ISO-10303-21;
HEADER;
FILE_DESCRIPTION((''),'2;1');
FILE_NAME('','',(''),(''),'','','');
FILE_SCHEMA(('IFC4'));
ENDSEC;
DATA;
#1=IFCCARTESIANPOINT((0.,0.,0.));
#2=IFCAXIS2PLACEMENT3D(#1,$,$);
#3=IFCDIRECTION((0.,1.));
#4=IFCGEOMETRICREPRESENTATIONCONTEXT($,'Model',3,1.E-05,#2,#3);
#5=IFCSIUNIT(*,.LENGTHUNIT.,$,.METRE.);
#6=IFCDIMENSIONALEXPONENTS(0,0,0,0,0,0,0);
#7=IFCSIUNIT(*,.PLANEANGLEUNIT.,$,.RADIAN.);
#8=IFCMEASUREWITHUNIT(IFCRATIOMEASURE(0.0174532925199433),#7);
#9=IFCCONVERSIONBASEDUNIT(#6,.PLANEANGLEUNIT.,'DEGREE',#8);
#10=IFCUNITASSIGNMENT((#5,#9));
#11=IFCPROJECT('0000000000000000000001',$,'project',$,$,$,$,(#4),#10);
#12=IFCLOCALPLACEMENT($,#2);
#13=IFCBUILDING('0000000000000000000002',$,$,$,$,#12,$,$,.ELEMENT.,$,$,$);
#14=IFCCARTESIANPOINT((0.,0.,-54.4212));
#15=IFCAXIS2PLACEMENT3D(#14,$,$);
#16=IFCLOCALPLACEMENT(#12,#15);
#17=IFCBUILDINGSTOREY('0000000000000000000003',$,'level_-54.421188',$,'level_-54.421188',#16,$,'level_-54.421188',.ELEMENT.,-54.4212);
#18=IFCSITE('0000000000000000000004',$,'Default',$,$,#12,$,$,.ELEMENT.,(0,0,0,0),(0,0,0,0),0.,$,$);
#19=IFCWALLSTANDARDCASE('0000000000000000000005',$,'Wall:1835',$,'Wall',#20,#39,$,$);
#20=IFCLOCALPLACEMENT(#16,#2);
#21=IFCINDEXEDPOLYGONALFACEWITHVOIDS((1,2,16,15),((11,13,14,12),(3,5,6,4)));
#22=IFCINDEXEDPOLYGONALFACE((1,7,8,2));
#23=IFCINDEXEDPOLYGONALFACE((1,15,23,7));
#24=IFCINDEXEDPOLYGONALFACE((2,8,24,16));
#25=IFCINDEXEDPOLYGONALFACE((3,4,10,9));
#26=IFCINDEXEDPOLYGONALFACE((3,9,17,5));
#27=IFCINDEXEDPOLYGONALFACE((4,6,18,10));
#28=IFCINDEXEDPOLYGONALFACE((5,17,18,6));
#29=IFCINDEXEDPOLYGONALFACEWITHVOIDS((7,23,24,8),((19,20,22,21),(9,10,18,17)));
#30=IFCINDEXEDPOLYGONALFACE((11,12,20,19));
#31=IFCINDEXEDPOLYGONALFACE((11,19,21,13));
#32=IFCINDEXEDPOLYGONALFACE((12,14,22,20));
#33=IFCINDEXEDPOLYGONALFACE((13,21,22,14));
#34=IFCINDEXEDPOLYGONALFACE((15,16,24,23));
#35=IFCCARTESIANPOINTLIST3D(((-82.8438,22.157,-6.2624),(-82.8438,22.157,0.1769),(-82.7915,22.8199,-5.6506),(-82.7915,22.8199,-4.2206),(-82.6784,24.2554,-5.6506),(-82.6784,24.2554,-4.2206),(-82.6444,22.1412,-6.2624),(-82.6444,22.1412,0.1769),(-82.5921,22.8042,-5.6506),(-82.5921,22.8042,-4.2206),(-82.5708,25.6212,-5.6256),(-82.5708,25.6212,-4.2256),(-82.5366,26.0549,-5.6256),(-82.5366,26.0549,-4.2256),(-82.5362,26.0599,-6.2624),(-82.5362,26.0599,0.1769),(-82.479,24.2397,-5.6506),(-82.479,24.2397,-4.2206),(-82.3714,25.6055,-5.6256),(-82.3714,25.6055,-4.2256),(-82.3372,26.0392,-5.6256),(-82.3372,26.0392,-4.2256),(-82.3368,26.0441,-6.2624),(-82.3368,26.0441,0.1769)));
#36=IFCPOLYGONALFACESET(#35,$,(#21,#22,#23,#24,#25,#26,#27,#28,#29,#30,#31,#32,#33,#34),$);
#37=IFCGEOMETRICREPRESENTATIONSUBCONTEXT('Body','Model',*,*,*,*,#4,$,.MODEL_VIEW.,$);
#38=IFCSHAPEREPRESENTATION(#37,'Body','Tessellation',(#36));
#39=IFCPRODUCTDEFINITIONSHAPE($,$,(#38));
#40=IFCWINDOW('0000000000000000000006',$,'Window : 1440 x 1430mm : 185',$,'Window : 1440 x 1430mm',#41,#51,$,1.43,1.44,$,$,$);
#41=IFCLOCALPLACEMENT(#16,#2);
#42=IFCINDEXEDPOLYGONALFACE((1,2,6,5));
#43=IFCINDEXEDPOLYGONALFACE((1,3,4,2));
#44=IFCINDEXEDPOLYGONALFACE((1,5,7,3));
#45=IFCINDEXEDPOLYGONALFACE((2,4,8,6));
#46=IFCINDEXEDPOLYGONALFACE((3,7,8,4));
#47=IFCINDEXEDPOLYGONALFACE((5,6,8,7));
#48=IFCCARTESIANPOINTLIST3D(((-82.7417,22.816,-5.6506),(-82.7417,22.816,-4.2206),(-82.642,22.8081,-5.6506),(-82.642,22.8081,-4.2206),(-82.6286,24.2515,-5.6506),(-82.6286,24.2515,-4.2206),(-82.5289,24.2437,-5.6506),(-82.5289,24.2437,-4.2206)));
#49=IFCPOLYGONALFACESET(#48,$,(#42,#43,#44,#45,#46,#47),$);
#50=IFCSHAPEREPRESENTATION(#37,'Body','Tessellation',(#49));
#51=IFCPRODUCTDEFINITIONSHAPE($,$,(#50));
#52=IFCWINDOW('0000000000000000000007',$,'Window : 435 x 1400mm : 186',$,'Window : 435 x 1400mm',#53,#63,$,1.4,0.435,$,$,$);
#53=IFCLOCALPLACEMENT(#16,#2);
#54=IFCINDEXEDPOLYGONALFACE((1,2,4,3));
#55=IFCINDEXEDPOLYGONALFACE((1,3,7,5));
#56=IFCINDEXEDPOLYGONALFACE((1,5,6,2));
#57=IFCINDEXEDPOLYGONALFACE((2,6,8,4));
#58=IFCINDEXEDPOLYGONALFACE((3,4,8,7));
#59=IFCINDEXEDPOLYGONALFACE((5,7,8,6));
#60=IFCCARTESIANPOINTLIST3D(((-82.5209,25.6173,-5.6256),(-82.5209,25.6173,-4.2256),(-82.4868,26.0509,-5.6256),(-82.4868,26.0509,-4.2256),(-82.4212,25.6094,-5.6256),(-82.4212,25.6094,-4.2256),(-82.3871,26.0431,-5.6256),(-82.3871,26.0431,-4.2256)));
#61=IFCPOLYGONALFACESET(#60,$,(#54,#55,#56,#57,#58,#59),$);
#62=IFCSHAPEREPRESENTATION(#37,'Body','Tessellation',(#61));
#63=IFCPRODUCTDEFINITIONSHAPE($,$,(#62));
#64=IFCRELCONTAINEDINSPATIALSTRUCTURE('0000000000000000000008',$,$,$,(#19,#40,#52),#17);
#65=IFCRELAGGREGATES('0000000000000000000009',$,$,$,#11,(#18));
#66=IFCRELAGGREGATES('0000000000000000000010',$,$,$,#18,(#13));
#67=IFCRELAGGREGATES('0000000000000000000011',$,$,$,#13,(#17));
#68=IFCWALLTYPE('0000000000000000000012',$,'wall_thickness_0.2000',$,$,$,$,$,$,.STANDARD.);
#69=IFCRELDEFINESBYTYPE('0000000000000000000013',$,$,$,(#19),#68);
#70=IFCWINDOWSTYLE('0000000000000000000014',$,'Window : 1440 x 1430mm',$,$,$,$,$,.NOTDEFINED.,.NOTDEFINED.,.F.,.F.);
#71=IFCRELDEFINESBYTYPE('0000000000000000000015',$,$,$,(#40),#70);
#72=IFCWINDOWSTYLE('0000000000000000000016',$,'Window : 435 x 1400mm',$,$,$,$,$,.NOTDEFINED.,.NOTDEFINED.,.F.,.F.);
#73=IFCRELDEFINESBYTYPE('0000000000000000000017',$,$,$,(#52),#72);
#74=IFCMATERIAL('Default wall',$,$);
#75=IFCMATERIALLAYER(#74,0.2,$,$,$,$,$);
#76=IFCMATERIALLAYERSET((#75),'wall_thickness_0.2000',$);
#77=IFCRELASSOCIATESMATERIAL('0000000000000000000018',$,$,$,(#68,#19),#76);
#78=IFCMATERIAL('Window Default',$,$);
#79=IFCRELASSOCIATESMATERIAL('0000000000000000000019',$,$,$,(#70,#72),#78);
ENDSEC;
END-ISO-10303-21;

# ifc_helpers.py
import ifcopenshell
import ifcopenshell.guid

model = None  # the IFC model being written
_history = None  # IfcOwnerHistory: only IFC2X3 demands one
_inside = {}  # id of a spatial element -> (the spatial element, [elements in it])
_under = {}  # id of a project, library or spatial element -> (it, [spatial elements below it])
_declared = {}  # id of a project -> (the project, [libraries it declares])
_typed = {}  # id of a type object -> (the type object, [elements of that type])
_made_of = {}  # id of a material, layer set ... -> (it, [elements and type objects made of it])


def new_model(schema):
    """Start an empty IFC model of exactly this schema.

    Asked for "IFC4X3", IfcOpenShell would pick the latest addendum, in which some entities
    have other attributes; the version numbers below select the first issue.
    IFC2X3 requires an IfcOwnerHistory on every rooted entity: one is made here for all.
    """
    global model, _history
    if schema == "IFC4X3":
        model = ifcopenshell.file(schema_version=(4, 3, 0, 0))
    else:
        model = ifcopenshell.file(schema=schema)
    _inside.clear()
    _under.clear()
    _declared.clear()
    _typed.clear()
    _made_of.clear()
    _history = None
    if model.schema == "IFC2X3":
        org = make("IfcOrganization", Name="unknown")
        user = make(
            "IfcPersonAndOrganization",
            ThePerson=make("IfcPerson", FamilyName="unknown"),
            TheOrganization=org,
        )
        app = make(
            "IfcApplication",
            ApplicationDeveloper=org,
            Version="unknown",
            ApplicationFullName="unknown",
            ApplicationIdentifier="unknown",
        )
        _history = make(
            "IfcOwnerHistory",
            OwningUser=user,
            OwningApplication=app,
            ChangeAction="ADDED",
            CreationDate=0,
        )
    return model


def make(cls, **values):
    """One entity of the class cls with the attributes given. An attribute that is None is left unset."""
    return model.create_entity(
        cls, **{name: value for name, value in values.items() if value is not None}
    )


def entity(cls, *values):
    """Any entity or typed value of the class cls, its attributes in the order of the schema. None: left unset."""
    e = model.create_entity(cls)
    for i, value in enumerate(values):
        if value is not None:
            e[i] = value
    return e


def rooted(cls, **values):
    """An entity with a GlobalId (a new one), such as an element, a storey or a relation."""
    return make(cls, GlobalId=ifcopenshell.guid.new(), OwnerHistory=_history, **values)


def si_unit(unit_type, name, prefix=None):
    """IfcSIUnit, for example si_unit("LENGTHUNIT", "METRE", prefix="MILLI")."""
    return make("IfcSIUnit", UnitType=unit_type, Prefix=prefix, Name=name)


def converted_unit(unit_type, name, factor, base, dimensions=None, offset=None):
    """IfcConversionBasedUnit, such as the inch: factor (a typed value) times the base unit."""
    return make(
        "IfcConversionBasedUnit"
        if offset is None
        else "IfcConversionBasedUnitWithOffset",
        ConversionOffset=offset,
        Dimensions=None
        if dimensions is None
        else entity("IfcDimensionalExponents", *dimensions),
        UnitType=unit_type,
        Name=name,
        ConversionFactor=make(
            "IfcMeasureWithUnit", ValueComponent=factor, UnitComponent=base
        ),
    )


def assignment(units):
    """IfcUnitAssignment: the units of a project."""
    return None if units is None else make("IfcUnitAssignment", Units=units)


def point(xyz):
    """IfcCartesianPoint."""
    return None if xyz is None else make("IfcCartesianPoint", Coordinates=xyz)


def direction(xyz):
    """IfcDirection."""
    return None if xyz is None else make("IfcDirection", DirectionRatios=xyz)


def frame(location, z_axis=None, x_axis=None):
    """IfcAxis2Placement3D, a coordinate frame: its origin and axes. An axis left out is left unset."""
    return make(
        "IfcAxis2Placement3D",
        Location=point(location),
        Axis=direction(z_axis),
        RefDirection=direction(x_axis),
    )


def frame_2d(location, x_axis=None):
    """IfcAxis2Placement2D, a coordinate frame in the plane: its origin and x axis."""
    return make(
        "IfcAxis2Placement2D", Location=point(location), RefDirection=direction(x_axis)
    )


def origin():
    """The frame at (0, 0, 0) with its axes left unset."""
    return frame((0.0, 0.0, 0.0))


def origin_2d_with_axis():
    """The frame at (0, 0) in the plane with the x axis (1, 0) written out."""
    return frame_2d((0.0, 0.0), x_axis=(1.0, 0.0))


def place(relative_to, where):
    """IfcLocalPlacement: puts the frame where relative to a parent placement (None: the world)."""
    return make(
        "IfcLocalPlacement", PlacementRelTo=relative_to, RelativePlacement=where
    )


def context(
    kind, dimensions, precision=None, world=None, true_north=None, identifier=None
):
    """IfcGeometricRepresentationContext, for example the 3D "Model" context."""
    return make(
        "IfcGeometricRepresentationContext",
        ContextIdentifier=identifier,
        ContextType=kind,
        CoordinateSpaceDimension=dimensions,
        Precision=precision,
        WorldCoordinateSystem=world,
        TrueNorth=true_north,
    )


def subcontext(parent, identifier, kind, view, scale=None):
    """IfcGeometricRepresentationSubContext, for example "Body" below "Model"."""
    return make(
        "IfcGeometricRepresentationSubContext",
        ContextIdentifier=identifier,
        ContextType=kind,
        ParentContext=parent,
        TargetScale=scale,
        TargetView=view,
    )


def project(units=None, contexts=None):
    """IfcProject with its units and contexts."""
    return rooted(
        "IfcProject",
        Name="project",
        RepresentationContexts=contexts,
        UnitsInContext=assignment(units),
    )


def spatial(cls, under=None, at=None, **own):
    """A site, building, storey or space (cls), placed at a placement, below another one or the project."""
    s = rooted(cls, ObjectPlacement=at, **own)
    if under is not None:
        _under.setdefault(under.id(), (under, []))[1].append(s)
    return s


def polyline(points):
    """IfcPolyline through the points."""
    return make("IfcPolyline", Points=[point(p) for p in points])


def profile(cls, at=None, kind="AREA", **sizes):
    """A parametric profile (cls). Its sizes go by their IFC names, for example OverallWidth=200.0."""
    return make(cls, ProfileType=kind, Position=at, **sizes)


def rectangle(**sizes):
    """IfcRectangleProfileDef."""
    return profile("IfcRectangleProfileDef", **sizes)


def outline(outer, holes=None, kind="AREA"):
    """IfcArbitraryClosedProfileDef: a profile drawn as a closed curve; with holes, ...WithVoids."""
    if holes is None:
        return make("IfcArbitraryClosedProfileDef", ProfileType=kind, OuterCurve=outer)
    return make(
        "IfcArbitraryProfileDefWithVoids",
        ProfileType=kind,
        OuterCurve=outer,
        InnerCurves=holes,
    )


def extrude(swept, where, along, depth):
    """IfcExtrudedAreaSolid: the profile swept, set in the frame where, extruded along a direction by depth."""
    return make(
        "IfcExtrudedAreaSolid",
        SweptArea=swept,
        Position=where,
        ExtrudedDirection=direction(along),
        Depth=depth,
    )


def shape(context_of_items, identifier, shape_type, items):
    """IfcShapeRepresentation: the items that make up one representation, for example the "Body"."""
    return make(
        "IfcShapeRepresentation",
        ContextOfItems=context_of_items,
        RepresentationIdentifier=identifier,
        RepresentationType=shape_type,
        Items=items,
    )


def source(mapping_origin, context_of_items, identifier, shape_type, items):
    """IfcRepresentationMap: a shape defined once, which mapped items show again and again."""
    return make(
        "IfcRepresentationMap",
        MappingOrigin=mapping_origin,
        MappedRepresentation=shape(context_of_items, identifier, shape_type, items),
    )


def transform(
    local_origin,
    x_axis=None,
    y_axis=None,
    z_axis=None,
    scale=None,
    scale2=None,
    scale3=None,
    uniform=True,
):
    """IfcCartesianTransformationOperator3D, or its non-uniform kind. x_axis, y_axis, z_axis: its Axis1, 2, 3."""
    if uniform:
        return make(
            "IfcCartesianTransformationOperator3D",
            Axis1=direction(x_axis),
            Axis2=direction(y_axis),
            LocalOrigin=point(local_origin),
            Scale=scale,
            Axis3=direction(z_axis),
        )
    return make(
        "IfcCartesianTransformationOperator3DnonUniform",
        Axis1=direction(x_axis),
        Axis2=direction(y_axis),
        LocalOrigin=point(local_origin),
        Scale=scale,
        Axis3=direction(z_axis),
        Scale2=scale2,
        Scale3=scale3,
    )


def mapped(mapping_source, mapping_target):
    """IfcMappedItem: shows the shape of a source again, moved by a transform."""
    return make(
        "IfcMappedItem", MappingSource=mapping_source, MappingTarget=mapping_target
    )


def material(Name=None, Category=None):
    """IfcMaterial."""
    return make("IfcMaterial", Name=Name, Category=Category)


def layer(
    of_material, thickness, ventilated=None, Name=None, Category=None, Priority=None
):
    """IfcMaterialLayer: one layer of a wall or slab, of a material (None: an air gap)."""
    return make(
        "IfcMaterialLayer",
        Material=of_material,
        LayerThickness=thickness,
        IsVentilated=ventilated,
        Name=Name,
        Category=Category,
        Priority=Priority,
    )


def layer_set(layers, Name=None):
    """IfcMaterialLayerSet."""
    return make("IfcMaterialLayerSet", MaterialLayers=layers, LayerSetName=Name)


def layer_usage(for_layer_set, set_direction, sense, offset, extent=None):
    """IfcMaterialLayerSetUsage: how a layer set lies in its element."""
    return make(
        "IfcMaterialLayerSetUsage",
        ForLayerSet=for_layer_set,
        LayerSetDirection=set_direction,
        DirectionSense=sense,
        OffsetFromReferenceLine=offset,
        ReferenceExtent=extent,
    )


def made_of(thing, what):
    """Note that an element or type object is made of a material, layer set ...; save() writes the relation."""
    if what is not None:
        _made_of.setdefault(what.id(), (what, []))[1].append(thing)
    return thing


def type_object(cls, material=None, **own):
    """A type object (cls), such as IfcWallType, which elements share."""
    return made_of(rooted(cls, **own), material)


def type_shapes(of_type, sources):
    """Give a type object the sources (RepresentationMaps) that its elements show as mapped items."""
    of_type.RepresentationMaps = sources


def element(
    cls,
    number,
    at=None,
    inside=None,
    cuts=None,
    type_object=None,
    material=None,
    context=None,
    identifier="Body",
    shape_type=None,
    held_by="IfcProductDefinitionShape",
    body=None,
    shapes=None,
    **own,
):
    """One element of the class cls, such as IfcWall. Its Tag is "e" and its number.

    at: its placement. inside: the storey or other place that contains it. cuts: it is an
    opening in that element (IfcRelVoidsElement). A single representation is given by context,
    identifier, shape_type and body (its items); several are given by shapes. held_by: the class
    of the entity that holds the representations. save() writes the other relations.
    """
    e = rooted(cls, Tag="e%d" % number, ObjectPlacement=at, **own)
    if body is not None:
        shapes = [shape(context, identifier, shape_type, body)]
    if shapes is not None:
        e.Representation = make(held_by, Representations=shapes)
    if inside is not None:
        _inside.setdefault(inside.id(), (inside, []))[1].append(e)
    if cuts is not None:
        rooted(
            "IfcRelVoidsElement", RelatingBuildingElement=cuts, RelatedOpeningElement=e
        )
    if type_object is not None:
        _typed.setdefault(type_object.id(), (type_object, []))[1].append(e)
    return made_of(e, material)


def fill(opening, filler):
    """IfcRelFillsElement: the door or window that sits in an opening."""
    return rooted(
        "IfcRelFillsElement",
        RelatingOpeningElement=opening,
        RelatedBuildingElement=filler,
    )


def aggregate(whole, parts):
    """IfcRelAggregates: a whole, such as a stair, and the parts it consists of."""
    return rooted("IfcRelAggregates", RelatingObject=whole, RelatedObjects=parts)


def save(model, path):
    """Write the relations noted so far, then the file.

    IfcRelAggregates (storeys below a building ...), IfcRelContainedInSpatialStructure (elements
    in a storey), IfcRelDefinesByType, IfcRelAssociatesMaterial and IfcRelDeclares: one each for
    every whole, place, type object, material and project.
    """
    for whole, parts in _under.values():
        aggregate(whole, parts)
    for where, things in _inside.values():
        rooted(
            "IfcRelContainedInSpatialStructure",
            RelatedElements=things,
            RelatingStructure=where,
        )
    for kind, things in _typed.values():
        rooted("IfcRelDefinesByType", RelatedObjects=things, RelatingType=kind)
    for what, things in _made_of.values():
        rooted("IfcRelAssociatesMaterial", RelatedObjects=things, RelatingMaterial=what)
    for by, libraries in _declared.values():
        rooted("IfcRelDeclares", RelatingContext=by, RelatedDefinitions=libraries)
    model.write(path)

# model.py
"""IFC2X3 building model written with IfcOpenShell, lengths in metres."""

from ifc_helpers import new_model, entity, si_unit, converted_unit, direction, frame, frame_2d, origin, origin_2d_with_axis, place, context, subcontext, project, spatial, polyline, rectangle, outline, extrude, source, transform, mapped, material, layer, layer_set, layer_usage, type_object, type_shapes, element, fill, save


model = new_model("IFC2X3")

# Units and contexts
model_context = context("Model", 3, precision=1e-05, world=origin(), true_north=direction((0.0, 1.0)))
body_context = subcontext(model_context, "Body", "Model", "MODEL_VIEW")
ifc_project = project(units=[si_unit("LENGTHUNIT", "METRE"), converted_unit("PLANEANGLEUNIT", "DEGREE", entity("IfcRatioMeasure", 0.0174532925199433), si_unit("PLANEANGLEUNIT", "RADIAN"), dimensions=[0, 0, 0, 0, 0, 0, 0])], contexts=[model_context])

# Site, building, storey
placement_1 = place(None, origin())
site = spatial("IfcSite", under=ifc_project, at=placement_1, Name="Default", CompositionType="ELEMENT", RefLatitude=(0, 0, 0, 0), RefLongitude=(0, 0, 0, 0), RefElevation=0.0)
building = spatial("IfcBuilding", under=site, at=placement_1, CompositionType="ELEMENT")
storey_placement = place(placement_1, frame((0.0, 0.0, -54.4212)))
storey = spatial("IfcBuildingStorey", under=building, at=storey_placement, Name="level_-54.421188", ObjectType="level_-54.421188", LongName="level_-54.421188", CompositionType="ELEMENT", Elevation=-54.4212)

# Shared definitions
ifc_material_1 = material(Name="Default wall")
ifc_layer = layer(ifc_material_1, 0.2)
ifc_layer_set = layer_set([ifc_layer], Name="wall_thickness_0.2000")
ifc_layer_usage = layer_usage(ifc_layer_set, "AXIS2", "POSITIVE", -0.1)
wall_type = type_object("IfcWallType", Name="wall_thickness_0.2000", PredefinedType="STANDARD", material=ifc_layer_set)
ifc_material_2 = material(Name="Window Default")

# Wall, openings, windows
placement_2 = place(placement_1, frame((0.0, 0.0, -60.6836)))
wall_1_placement = place(placement_2, frame((-82.4365, 26.052, 0.0), z_axis=(0.0, 0.0, 1.0), x_axis=(-0.07856, -0.996909, 0.0)))
wall_1 = element("IfcWallStandardCase", 1, at=wall_1_placement, inside=storey, type_object=wall_type, material=ifc_layer_usage, Name="Wall:1835", ObjectType="Wall", context=body_context, shape_type="SweptSolid", body=[
    extrude(outline(polyline([(3.915, -0.1), (3.915, 0.1), (0.0, 0.1), (0.0, -0.1), (3.915, -0.1)])), origin(), (0.0, 0.0, 1.0), 6.4393),
])
opening_1_placement = place(wall_1_placement, frame((1.81, -0.1, 0.6117)))
opening_1 = element("IfcOpeningElement", 2, at=opening_1_placement, cuts=wall_1, ObjectType="Opening", context=body_context, shape_type="SweptSolid", body=[
    extrude(rectangle(XDim=1.44, YDim=1.43, at=frame_2d((0.715, 0.72), x_axis=(0.0, 1.0))), frame((0.0, 0.0, 0.0), z_axis=(0.0, 1.0, 0.0), x_axis=(0.0, 0.0, 1.0)), (0.0, 0.0, 1.0), 0.2),
])
opening_2_placement = place(wall_1_placement, frame((0.005, -0.1, 0.6367)))
opening_2 = element("IfcOpeningElement", 3, at=opening_2_placement, cuts=wall_1, ObjectType="Opening", context=body_context, shape_type="SweptSolid", body=[
    extrude(rectangle(XDim=0.435, YDim=1.4, at=frame_2d((0.7, 0.2175), x_axis=(0.0, 1.0))), frame((0.0, 0.0, 0.0), z_axis=(0.0, 1.0, 0.0), x_axis=(0.0, 0.0, 1.0)), (0.0, 0.0, 1.0), 0.2),
])
window_style_1 = type_object("IfcWindowStyle", Name="Window : 1440 x 1430mm", ConstructionType="NOTDEFINED", OperationType="NOTDEFINED", ParameterTakesPrecedence=False, Sizeable=False, material=ifc_material_2)
shared_shape_1 = source(origin(), body_context, "Body", "SweptSolid", [
    extrude(rectangle(XDim=0.1, YDim=1.44, at=origin_2d_with_axis()), frame((0.72, 0.1, 0.0), z_axis=(0.0, 0.0, 1.0), x_axis=(0.0, 1.0, 0.0)), (0.0, 0.0, 1.0), 1.43),
])
type_shapes(window_style_1, [shared_shape_1])
window_1_placement = place(opening_1_placement, origin())
window_1 = element("IfcWindow", 4, at=window_1_placement, inside=storey, type_object=window_style_1, Name="Window : 1440 x 1430mm : 185", ObjectType="Window : 1440 x 1430mm", OverallHeight=1.43, OverallWidth=1.44, context=body_context, shape_type="MappedRepresentation", body=[
    mapped(shared_shape_1, transform((0.0, 0.0, 0.0), scale=1.0)),
])
fill(opening_1, window_1)
window_style_2 = type_object("IfcWindowStyle", Name="Window : 435 x 1400mm", ConstructionType="NOTDEFINED", OperationType="NOTDEFINED", ParameterTakesPrecedence=False, Sizeable=False, material=ifc_material_2)
shared_shape_2 = source(origin(), body_context, "Body", "SweptSolid", [
    extrude(rectangle(XDim=0.1, YDim=0.435, at=origin_2d_with_axis()), frame((0.2175, 0.1, 0.0), z_axis=(0.0, 0.0, 1.0), x_axis=(0.0, 1.0, 0.0)), (0.0, 0.0, 1.0), 1.4),
])
type_shapes(window_style_2, [shared_shape_2])
window_2_placement = place(opening_2_placement, origin())
window_2 = element("IfcWindow", 5, at=window_2_placement, inside=storey, type_object=window_style_2, Name="Window : 435 x 1400mm : 186", ObjectType="Window : 435 x 1400mm", OverallHeight=1.4, OverallWidth=0.435, context=body_context, shape_type="MappedRepresentation", body=[
    mapped(shared_shape_2, transform((0.0, 0.0, 0.0), scale=1.0)),
])
fill(opening_2, window_2)

save(model, "model.ifc")
